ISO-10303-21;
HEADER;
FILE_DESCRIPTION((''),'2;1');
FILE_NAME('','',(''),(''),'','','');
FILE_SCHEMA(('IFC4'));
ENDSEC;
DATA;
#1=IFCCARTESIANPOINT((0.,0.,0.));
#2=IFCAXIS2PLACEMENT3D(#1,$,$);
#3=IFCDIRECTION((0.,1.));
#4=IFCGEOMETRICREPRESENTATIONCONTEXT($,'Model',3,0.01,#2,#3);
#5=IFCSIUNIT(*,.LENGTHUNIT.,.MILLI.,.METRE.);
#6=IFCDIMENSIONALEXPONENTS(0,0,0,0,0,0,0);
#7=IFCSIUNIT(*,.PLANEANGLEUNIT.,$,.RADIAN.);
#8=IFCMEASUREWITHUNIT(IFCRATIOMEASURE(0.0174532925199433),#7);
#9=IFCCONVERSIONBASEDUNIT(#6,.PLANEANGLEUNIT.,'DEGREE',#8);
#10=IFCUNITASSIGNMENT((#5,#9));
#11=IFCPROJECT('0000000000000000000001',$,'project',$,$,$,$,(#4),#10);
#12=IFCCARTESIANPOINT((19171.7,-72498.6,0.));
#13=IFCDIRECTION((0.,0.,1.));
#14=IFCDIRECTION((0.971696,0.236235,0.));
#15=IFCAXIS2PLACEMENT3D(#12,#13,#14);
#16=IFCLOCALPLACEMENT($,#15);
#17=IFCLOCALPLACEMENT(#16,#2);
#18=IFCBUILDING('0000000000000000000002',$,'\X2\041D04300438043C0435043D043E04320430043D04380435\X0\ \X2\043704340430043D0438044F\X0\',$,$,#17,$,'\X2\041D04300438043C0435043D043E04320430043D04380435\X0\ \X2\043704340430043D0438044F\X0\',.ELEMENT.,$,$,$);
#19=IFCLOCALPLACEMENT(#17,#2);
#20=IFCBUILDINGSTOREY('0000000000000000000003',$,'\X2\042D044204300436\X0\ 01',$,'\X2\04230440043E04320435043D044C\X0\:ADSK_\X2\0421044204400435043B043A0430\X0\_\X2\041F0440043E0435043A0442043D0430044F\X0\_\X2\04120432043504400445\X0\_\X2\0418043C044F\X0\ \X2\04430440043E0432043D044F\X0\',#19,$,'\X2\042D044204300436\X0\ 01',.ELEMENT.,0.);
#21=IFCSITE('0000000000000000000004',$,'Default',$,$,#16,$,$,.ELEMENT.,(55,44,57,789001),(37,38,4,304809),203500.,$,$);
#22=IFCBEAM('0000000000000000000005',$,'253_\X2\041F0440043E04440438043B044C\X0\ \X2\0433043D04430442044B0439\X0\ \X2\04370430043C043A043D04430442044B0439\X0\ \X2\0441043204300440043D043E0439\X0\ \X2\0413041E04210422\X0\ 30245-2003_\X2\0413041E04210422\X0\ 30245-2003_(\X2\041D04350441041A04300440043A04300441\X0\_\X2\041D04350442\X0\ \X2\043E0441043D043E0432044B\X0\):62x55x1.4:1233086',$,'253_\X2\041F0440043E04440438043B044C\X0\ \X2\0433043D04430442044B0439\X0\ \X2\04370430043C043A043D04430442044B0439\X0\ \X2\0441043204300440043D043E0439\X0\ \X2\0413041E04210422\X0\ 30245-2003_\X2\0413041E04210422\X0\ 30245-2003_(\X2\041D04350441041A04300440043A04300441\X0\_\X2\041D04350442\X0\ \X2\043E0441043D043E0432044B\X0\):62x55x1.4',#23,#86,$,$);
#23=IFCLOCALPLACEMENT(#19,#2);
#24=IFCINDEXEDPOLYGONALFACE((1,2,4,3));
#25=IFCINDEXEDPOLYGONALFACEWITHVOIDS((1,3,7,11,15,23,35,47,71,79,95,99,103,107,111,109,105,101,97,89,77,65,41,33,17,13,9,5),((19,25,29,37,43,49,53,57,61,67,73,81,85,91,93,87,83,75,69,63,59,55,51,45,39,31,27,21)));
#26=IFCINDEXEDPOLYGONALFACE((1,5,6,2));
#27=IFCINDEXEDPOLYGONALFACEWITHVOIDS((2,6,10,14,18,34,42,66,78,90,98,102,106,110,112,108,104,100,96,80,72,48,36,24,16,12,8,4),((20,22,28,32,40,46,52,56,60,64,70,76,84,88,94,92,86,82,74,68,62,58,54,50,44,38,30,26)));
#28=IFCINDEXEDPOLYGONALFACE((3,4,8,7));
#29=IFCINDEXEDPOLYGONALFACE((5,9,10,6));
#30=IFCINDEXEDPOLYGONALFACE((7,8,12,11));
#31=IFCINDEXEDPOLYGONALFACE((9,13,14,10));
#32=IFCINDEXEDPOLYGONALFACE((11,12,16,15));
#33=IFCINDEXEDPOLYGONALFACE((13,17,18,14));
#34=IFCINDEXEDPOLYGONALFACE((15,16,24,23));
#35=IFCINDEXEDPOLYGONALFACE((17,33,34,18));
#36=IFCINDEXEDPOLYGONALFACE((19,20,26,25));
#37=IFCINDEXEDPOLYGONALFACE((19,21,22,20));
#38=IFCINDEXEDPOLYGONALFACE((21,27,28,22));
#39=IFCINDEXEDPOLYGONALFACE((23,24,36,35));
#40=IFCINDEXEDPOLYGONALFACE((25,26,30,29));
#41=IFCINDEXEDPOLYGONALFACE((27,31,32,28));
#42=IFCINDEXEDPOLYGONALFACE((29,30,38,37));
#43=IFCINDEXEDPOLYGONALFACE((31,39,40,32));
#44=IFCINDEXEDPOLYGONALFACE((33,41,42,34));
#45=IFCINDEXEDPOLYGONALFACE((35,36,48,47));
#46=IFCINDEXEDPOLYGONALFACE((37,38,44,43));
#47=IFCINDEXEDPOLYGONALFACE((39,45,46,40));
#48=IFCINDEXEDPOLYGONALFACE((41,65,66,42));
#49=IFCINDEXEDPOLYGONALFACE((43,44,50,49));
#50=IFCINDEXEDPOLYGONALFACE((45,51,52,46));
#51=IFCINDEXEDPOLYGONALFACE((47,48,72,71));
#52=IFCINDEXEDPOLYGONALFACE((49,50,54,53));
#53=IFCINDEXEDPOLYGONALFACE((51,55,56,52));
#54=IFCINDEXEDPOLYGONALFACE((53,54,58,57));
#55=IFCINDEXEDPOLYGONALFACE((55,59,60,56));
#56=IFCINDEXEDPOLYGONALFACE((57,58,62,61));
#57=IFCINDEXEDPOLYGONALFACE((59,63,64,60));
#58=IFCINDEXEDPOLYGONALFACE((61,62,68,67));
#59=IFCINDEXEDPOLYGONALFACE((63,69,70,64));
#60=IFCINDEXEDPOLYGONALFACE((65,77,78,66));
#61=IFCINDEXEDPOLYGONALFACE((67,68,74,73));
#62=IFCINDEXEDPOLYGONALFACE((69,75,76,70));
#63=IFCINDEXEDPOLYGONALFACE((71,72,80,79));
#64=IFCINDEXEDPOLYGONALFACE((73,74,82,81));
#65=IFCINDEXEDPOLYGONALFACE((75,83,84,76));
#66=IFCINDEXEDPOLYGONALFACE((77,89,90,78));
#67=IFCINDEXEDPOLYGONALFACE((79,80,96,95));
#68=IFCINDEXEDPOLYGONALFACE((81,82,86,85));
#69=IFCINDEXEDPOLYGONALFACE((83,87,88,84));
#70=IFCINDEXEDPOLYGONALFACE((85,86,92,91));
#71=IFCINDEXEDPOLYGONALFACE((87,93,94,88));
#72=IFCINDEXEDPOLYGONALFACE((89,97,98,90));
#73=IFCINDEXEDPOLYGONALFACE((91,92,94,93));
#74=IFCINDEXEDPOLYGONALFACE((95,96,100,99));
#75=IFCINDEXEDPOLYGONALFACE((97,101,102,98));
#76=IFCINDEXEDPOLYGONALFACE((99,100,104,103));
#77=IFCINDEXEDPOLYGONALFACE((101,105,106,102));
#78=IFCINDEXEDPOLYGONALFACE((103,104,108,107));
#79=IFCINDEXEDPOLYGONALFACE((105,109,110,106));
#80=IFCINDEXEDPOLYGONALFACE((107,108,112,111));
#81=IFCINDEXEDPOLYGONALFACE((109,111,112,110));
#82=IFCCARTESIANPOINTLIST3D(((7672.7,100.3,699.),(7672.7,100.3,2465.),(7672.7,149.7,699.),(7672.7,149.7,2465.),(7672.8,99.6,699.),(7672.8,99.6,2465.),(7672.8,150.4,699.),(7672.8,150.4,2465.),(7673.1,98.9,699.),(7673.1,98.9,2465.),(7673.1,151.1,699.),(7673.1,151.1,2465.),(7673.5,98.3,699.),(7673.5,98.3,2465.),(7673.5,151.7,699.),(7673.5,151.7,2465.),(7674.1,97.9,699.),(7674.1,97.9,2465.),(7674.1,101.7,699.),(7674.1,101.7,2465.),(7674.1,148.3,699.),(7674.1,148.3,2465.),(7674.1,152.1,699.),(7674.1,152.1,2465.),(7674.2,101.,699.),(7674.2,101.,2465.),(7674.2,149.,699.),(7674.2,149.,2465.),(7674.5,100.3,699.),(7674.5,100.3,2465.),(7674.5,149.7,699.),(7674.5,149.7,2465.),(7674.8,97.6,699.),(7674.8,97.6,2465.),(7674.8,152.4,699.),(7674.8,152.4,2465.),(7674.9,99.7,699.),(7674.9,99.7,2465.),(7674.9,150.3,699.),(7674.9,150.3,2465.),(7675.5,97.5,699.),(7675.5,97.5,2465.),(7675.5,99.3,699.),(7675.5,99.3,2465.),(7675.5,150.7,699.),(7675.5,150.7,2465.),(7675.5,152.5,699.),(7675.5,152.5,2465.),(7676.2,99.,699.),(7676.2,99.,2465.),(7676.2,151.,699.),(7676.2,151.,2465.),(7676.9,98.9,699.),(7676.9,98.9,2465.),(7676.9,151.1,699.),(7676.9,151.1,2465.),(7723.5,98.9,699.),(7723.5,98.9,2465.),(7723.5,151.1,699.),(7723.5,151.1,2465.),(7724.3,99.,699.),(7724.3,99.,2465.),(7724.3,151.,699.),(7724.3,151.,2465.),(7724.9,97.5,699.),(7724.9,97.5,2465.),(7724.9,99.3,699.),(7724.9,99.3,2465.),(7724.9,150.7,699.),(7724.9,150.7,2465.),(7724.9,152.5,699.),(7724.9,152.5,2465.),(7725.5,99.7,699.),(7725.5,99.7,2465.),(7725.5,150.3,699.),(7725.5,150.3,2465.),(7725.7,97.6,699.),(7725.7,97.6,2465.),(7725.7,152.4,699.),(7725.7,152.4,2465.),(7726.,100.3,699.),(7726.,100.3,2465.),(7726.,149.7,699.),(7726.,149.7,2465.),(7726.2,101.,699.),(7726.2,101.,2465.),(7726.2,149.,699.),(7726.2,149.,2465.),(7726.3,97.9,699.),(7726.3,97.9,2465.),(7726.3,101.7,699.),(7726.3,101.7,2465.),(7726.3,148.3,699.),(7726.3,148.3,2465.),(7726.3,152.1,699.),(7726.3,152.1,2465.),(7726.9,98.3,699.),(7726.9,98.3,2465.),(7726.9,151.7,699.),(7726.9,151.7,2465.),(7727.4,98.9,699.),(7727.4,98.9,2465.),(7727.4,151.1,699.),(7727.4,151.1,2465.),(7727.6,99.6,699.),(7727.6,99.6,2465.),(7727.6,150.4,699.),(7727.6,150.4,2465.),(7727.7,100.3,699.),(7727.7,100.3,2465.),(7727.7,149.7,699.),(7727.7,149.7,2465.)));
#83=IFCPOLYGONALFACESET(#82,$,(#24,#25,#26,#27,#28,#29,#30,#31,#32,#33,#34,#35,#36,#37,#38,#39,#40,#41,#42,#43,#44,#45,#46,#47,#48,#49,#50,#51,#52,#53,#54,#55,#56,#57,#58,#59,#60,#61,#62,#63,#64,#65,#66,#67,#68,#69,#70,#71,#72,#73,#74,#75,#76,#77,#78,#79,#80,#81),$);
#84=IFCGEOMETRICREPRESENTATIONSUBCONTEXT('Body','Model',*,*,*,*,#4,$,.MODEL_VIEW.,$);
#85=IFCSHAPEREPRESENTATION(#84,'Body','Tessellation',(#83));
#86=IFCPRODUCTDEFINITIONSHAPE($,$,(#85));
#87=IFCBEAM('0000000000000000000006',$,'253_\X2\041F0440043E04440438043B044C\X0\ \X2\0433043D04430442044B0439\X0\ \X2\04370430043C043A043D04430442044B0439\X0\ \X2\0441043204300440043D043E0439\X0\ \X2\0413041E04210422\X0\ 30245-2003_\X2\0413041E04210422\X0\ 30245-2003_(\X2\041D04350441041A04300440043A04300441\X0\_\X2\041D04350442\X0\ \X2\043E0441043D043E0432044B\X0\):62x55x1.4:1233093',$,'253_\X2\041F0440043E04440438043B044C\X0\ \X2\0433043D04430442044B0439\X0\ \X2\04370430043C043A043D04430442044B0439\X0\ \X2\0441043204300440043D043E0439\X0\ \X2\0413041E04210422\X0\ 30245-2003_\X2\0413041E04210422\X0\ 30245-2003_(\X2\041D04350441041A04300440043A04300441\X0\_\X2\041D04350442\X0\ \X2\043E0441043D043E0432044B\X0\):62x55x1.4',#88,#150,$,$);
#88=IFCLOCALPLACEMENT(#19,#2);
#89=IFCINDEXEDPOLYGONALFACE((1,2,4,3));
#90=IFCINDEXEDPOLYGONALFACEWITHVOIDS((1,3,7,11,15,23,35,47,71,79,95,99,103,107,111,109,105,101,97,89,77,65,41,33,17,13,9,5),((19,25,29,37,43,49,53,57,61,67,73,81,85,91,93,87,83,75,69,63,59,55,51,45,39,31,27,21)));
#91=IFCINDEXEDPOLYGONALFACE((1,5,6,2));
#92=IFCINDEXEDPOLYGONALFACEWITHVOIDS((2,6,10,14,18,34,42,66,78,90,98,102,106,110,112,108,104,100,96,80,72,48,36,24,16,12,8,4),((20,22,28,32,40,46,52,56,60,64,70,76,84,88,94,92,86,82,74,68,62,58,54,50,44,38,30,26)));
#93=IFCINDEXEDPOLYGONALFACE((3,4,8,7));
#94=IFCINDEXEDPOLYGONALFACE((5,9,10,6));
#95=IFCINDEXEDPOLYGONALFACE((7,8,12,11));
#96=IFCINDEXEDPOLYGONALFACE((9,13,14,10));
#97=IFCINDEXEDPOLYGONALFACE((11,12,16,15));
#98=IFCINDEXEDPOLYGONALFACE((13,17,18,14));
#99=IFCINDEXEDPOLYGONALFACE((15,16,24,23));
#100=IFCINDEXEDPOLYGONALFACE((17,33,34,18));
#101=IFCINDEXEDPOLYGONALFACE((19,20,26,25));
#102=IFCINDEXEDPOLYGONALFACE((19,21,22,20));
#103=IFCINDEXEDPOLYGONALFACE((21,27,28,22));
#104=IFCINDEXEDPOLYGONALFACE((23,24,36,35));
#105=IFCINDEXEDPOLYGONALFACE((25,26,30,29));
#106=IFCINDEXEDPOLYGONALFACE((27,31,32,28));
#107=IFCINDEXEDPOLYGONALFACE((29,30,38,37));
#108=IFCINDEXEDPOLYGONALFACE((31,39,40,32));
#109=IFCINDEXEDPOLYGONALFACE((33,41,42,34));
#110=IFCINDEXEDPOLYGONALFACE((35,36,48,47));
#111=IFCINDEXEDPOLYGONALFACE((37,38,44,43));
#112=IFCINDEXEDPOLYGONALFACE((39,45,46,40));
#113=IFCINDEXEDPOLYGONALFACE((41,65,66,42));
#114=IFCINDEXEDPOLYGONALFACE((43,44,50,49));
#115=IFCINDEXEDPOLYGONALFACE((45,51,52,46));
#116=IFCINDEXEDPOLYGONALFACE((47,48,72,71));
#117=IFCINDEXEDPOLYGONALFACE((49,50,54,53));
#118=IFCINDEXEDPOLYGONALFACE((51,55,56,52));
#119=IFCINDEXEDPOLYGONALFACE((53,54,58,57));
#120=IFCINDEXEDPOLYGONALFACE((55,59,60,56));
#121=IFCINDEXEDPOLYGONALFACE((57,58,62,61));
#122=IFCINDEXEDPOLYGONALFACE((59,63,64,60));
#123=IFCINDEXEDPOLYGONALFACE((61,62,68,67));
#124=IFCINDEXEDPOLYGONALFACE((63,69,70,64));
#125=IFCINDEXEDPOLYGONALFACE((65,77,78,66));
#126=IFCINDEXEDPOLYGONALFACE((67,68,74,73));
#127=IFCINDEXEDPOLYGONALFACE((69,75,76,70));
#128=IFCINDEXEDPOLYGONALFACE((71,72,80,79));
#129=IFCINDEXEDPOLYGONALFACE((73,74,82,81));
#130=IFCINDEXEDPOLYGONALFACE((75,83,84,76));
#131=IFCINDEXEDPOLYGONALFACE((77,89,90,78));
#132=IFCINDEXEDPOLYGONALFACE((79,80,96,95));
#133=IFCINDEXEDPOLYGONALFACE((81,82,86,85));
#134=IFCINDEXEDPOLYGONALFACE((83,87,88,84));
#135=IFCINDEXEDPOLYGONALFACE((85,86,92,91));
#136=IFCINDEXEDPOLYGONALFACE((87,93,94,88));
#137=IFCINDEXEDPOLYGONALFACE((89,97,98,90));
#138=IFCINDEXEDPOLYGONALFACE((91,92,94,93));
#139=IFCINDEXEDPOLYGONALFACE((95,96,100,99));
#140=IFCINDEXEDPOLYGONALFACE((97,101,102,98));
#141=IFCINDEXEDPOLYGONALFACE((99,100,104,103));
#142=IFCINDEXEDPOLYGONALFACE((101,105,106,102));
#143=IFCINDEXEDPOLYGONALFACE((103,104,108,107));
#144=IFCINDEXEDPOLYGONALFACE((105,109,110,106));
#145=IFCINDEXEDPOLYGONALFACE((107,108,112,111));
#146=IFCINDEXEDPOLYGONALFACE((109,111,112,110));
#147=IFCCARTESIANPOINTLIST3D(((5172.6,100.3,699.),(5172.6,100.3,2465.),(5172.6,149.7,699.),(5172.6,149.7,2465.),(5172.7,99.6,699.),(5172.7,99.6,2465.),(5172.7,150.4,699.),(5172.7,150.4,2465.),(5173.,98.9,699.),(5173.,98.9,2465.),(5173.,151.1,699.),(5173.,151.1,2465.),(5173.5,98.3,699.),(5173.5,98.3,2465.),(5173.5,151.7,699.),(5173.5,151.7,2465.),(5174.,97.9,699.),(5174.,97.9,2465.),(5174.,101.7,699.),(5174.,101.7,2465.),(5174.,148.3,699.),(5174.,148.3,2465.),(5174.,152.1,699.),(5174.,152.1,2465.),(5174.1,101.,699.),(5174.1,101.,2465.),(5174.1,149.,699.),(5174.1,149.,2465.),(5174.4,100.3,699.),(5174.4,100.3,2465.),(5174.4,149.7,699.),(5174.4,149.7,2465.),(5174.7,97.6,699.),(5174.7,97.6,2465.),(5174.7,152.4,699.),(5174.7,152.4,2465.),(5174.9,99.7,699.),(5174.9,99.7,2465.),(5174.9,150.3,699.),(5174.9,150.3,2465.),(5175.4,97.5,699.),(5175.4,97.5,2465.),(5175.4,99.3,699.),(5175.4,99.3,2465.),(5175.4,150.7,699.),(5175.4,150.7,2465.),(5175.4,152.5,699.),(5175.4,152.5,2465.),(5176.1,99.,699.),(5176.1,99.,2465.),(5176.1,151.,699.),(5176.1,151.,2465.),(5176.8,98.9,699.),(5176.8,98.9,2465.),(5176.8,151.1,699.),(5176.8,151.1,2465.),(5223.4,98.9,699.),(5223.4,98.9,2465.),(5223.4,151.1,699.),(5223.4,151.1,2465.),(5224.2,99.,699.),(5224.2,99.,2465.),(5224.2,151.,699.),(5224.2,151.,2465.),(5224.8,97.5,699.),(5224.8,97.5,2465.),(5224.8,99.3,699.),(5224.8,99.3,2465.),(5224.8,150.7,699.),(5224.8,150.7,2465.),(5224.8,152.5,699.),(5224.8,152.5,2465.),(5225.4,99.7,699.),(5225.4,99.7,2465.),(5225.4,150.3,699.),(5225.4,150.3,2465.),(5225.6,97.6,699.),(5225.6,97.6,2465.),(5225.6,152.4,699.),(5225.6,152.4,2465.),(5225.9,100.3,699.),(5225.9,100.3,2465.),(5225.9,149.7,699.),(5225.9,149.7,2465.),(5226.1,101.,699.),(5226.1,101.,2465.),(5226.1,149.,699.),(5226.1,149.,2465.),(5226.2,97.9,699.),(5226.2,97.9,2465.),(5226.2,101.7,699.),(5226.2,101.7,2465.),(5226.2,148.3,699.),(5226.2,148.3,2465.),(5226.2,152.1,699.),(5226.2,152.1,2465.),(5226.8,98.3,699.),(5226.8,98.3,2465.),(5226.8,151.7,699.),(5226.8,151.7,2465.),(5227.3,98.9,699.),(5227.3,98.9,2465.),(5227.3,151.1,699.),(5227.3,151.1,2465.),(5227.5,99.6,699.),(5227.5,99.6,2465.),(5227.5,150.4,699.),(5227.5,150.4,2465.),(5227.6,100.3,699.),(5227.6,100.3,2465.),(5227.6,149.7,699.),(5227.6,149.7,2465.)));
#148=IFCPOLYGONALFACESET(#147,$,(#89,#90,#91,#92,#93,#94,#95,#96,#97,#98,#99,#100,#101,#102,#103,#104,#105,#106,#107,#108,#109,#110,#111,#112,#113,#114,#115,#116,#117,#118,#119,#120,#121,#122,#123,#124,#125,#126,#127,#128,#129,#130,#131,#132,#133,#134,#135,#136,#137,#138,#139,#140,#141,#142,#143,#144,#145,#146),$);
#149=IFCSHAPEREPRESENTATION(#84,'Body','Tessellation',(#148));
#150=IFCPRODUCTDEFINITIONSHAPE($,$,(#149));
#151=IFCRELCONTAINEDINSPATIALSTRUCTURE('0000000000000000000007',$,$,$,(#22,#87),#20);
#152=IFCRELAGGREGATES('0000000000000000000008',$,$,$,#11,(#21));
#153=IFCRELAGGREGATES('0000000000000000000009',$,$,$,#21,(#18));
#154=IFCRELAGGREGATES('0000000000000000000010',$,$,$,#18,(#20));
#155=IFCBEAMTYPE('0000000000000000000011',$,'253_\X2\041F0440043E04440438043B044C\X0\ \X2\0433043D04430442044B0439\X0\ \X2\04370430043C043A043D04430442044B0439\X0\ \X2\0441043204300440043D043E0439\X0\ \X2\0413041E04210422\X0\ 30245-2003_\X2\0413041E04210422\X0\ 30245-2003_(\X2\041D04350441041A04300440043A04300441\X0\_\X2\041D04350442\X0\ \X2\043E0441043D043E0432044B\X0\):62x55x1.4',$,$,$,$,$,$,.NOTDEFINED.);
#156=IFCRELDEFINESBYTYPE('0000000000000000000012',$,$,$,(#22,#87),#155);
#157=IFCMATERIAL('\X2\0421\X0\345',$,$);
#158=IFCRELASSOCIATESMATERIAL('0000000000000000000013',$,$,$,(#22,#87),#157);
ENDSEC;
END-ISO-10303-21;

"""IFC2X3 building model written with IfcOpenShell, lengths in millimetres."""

from ifc_helpers import new_model, entity, si_unit, converted_unit, direction, frame, frame_2d, origin, place, context, subcontext, project, spatial, polyline, circle_curve, parameter, trimmed, segment, composite_curve, outline, extrude, material, type_object, element, save


model = new_model("IFC2X3")

# Units and contexts
model_context = context("Model", 3, precision=0.01, world=origin(), true_north=direction((0.0, 1.0)))
body_context = subcontext(model_context, "Body", "Model", "MODEL_VIEW")
ifc_project = project(units=[si_unit("LENGTHUNIT", "METRE", prefix="MILLI"), converted_unit("PLANEANGLEUNIT", "DEGREE", entity("IfcRatioMeasure", 0.0174532925199433), si_unit("PLANEANGLEUNIT", "RADIAN"), dimensions=[0, 0, 0, 0, 0, 0, 0])], contexts=[model_context])

# Site, building, storey
site_placement = place(None, frame((19171.7, -72498.6, 0.0), z_axis=(0.0, 0.0, 1.0), x_axis=(0.971696, 0.236235, 0.0)))
site = spatial("IfcSite", under=ifc_project, at=site_placement, Name="Default", CompositionType="ELEMENT", RefLatitude=(55, 44, 57, 789001), RefLongitude=(37, 38, 4, 304809), RefElevation=203500.0)
building_placement = place(site_placement, origin())
building = spatial("IfcBuilding", under=site, at=building_placement, Name="Наименование здания", LongName="Наименование здания", CompositionType="ELEMENT")
storey_placement = place(building_placement, origin())
storey = spatial("IfcBuildingStorey", under=building, at=storey_placement, Name="Этаж 01", ObjectType="Уровень:ADSK_Стрелка_Проектная_Вверх_Имя уровня", LongName="Этаж 01", CompositionType="ELEMENT", Elevation=0.0)

# Beams
ifc_material_1 = material(Name="С345")
beam_type_1 = type_object("IfcBeamType", Name="253_Профиль гнутый замкнутый сварной ГОСТ 30245-2003_ГОСТ 30245-2003_(НесКаркас_Нет основы):62x55x1.4", PredefinedType="NOTDEFINED")
beam_1_placement = place(storey_placement, frame((7671.1, 95.9, 699.0), z_axis=(1.0, 0.0, 0.0), x_axis=(0.0, 0.0, 1.0)))
element("IfcBeam", 1, at=beam_1_placement, inside=storey, type_object=beam_type_1, material=ifc_material_1, Name="253_Профиль гнутый замкнутый сварной ГОСТ 30245-2003_ГОСТ 30245-2003_(НесКаркас_Нет основы):62x55x1.4:1233086", ObjectType="253_Профиль гнутый замкнутый сварной ГОСТ 30245-2003_ГОСТ 30245-2003_(НесКаркас_Нет основы):62x55x1.4", context=body_context, shape_type="SweptSolid", body=[
    extrude(outline(composite_curve([segment(trimmed(circle_curve(frame_2d((24.7, -24.7), x_axis=(1.0, 0.0)), 2.8), [parameter(270.0)], [parameter(0.0)], True, "PARAMETER"), True, "CONTINUOUS"), segment(polyline([(27.5, -24.7), (27.5, 24.7)]), True, "CONTINUOUS"), segment(trimmed(circle_curve(frame_2d((24.7, 24.7), x_axis=(1.0, 0.0)), 2.8), [parameter(0.0)], [parameter(90.0)], True, "PARAMETER"), True, "CONTINUOUS"), segment(polyline([(24.7, 27.5), (-24.7, 27.5)]), True, "CONTINUOUS"), segment(trimmed(circle_curve(frame_2d((-24.7, 24.7), x_axis=(1.0, 0.0)), 2.8), [parameter(90.0)], [parameter(180.0)], True, "PARAMETER"), True, "CONTINUOUS"), segment(polyline([(-27.5, 24.7), (-27.5, -24.7)]), True, "CONTINUOUS"), segment(trimmed(circle_curve(frame_2d((-24.7, -24.7), x_axis=(1.0, 0.0)), 2.8), [parameter(180.0)], [parameter(270.0)], True, "PARAMETER"), True, "CONTINUOUS"), segment(polyline([(-24.7, -27.5), (24.7, -27.5)]), True, "CONTINUOUS")], self_intersect=False), holes=[composite_curve([segment(polyline([(23.3, -26.1), (-23.3, -26.1)]), True, "CONTINUOUS"), segment(trimmed(circle_curve(frame_2d((-23.3, -23.3), x_axis=(1.0, 0.0)), 2.8), [parameter(180.0)], [parameter(270.0)], True, "PARAMETER"), False, "CONTINUOUS"), segment(polyline([(-26.1, -23.3), (-26.1, 23.3)]), True, "CONTINUOUS"), segment(trimmed(circle_curve(frame_2d((-23.3, 23.3), x_axis=(1.0, 0.0)), 2.8), [parameter(90.0)], [parameter(180.0)], True, "PARAMETER"), False, "CONTINUOUS"), segment(polyline([(-23.3, 26.1), (23.3, 26.1)]), True, "CONTINUOUS"), segment(trimmed(circle_curve(frame_2d((23.3, 23.3), x_axis=(1.0, 0.0)), 2.8), [parameter(0.0)], [parameter(90.0)], True, "PARAMETER"), False, "CONTINUOUS"), segment(polyline([(26.1, 23.3), (26.1, -23.3)]), True, "CONTINUOUS"), segment(trimmed(circle_curve(frame_2d((23.3, -23.3), x_axis=(1.0, 0.0)), 2.8), [parameter(270.0)], [parameter(0.0)], True, "PARAMETER"), False, "CONTINUOUS")], self_intersect=False)]), frame((0.0, -29.1, 29.1), z_axis=(1.0, 0.0, 0.0), x_axis=(0.0, -1.0, 0.0)), (0.0, 0.0, 1.0), 1766.0),
])
beam_2_placement = place(storey_placement, frame((5171.0, 95.9, 699.0), z_axis=(1.0, 0.0, 0.0), x_axis=(0.0, 0.0, 1.0)))
element("IfcBeam", 2, at=beam_2_placement, inside=storey, type_object=beam_type_1, material=ifc_material_1, Name="253_Профиль гнутый замкнутый сварной ГОСТ 30245-2003_ГОСТ 30245-2003_(НесКаркас_Нет основы):62x55x1.4:1233093", ObjectType="253_Профиль гнутый замкнутый сварной ГОСТ 30245-2003_ГОСТ 30245-2003_(НесКаркас_Нет основы):62x55x1.4", context=body_context, shape_type="SweptSolid", body=[
    extrude(outline(composite_curve([segment(trimmed(circle_curve(frame_2d((24.7, -24.7), x_axis=(1.0, 0.0)), 2.8), [parameter(270.0)], [parameter(0.0)], True, "PARAMETER"), True, "CONTINUOUS"), segment(polyline([(27.5, -24.7), (27.5, 24.7)]), True, "CONTINUOUS"), segment(trimmed(circle_curve(frame_2d((24.7, 24.7), x_axis=(1.0, 0.0)), 2.8), [parameter(0.0)], [parameter(90.0)], True, "PARAMETER"), True, "CONTINUOUS"), segment(polyline([(24.7, 27.5), (-24.7, 27.5)]), True, "CONTINUOUS"), segment(trimmed(circle_curve(frame_2d((-24.7, 24.7), x_axis=(1.0, 0.0)), 2.8), [parameter(90.0)], [parameter(180.0)], True, "PARAMETER"), True, "CONTINUOUS"), segment(polyline([(-27.5, 24.7), (-27.5, -24.7)]), True, "CONTINUOUS"), segment(trimmed(circle_curve(frame_2d((-24.7, -24.7), x_axis=(1.0, 0.0)), 2.8), [parameter(180.0)], [parameter(270.0)], True, "PARAMETER"), True, "CONTINUOUS"), segment(polyline([(-24.7, -27.5), (24.7, -27.5)]), True, "CONTINUOUS")], self_intersect=False), holes=[composite_curve([segment(polyline([(23.3, -26.1), (-23.3, -26.1)]), True, "CONTINUOUS"), segment(trimmed(circle_curve(frame_2d((-23.3, -23.3), x_axis=(1.0, 0.0)), 2.8), [parameter(180.0)], [parameter(270.0)], True, "PARAMETER"), False, "CONTINUOUS"), segment(polyline([(-26.1, -23.3), (-26.1, 23.3)]), True, "CONTINUOUS"), segment(trimmed(circle_curve(frame_2d((-23.3, 23.3), x_axis=(1.0, 0.0)), 2.8), [parameter(90.0)], [parameter(180.0)], True, "PARAMETER"), False, "CONTINUOUS"), segment(polyline([(-23.3, 26.1), (23.3, 26.1)]), True, "CONTINUOUS"), segment(trimmed(circle_curve(frame_2d((23.3, 23.3), x_axis=(1.0, 0.0)), 2.8), [parameter(0.0)], [parameter(90.0)], True, "PARAMETER"), False, "CONTINUOUS"), segment(polyline([(26.1, 23.3), (26.1, -23.3)]), True, "CONTINUOUS"), segment(trimmed(circle_curve(frame_2d((23.3, -23.3), x_axis=(1.0, 0.0)), 2.8), [parameter(270.0)], [parameter(0.0)], True, "PARAMETER"), False, "CONTINUOUS")], self_intersect=False)]), frame((0.0, -29.1, 29.1), z_axis=(1.0, 0.0, 0.0), x_axis=(0.0, -1.0, 0.0)), (0.0, 0.0, 1.0), 1766.0),
])

save(model, "model.ifc")
